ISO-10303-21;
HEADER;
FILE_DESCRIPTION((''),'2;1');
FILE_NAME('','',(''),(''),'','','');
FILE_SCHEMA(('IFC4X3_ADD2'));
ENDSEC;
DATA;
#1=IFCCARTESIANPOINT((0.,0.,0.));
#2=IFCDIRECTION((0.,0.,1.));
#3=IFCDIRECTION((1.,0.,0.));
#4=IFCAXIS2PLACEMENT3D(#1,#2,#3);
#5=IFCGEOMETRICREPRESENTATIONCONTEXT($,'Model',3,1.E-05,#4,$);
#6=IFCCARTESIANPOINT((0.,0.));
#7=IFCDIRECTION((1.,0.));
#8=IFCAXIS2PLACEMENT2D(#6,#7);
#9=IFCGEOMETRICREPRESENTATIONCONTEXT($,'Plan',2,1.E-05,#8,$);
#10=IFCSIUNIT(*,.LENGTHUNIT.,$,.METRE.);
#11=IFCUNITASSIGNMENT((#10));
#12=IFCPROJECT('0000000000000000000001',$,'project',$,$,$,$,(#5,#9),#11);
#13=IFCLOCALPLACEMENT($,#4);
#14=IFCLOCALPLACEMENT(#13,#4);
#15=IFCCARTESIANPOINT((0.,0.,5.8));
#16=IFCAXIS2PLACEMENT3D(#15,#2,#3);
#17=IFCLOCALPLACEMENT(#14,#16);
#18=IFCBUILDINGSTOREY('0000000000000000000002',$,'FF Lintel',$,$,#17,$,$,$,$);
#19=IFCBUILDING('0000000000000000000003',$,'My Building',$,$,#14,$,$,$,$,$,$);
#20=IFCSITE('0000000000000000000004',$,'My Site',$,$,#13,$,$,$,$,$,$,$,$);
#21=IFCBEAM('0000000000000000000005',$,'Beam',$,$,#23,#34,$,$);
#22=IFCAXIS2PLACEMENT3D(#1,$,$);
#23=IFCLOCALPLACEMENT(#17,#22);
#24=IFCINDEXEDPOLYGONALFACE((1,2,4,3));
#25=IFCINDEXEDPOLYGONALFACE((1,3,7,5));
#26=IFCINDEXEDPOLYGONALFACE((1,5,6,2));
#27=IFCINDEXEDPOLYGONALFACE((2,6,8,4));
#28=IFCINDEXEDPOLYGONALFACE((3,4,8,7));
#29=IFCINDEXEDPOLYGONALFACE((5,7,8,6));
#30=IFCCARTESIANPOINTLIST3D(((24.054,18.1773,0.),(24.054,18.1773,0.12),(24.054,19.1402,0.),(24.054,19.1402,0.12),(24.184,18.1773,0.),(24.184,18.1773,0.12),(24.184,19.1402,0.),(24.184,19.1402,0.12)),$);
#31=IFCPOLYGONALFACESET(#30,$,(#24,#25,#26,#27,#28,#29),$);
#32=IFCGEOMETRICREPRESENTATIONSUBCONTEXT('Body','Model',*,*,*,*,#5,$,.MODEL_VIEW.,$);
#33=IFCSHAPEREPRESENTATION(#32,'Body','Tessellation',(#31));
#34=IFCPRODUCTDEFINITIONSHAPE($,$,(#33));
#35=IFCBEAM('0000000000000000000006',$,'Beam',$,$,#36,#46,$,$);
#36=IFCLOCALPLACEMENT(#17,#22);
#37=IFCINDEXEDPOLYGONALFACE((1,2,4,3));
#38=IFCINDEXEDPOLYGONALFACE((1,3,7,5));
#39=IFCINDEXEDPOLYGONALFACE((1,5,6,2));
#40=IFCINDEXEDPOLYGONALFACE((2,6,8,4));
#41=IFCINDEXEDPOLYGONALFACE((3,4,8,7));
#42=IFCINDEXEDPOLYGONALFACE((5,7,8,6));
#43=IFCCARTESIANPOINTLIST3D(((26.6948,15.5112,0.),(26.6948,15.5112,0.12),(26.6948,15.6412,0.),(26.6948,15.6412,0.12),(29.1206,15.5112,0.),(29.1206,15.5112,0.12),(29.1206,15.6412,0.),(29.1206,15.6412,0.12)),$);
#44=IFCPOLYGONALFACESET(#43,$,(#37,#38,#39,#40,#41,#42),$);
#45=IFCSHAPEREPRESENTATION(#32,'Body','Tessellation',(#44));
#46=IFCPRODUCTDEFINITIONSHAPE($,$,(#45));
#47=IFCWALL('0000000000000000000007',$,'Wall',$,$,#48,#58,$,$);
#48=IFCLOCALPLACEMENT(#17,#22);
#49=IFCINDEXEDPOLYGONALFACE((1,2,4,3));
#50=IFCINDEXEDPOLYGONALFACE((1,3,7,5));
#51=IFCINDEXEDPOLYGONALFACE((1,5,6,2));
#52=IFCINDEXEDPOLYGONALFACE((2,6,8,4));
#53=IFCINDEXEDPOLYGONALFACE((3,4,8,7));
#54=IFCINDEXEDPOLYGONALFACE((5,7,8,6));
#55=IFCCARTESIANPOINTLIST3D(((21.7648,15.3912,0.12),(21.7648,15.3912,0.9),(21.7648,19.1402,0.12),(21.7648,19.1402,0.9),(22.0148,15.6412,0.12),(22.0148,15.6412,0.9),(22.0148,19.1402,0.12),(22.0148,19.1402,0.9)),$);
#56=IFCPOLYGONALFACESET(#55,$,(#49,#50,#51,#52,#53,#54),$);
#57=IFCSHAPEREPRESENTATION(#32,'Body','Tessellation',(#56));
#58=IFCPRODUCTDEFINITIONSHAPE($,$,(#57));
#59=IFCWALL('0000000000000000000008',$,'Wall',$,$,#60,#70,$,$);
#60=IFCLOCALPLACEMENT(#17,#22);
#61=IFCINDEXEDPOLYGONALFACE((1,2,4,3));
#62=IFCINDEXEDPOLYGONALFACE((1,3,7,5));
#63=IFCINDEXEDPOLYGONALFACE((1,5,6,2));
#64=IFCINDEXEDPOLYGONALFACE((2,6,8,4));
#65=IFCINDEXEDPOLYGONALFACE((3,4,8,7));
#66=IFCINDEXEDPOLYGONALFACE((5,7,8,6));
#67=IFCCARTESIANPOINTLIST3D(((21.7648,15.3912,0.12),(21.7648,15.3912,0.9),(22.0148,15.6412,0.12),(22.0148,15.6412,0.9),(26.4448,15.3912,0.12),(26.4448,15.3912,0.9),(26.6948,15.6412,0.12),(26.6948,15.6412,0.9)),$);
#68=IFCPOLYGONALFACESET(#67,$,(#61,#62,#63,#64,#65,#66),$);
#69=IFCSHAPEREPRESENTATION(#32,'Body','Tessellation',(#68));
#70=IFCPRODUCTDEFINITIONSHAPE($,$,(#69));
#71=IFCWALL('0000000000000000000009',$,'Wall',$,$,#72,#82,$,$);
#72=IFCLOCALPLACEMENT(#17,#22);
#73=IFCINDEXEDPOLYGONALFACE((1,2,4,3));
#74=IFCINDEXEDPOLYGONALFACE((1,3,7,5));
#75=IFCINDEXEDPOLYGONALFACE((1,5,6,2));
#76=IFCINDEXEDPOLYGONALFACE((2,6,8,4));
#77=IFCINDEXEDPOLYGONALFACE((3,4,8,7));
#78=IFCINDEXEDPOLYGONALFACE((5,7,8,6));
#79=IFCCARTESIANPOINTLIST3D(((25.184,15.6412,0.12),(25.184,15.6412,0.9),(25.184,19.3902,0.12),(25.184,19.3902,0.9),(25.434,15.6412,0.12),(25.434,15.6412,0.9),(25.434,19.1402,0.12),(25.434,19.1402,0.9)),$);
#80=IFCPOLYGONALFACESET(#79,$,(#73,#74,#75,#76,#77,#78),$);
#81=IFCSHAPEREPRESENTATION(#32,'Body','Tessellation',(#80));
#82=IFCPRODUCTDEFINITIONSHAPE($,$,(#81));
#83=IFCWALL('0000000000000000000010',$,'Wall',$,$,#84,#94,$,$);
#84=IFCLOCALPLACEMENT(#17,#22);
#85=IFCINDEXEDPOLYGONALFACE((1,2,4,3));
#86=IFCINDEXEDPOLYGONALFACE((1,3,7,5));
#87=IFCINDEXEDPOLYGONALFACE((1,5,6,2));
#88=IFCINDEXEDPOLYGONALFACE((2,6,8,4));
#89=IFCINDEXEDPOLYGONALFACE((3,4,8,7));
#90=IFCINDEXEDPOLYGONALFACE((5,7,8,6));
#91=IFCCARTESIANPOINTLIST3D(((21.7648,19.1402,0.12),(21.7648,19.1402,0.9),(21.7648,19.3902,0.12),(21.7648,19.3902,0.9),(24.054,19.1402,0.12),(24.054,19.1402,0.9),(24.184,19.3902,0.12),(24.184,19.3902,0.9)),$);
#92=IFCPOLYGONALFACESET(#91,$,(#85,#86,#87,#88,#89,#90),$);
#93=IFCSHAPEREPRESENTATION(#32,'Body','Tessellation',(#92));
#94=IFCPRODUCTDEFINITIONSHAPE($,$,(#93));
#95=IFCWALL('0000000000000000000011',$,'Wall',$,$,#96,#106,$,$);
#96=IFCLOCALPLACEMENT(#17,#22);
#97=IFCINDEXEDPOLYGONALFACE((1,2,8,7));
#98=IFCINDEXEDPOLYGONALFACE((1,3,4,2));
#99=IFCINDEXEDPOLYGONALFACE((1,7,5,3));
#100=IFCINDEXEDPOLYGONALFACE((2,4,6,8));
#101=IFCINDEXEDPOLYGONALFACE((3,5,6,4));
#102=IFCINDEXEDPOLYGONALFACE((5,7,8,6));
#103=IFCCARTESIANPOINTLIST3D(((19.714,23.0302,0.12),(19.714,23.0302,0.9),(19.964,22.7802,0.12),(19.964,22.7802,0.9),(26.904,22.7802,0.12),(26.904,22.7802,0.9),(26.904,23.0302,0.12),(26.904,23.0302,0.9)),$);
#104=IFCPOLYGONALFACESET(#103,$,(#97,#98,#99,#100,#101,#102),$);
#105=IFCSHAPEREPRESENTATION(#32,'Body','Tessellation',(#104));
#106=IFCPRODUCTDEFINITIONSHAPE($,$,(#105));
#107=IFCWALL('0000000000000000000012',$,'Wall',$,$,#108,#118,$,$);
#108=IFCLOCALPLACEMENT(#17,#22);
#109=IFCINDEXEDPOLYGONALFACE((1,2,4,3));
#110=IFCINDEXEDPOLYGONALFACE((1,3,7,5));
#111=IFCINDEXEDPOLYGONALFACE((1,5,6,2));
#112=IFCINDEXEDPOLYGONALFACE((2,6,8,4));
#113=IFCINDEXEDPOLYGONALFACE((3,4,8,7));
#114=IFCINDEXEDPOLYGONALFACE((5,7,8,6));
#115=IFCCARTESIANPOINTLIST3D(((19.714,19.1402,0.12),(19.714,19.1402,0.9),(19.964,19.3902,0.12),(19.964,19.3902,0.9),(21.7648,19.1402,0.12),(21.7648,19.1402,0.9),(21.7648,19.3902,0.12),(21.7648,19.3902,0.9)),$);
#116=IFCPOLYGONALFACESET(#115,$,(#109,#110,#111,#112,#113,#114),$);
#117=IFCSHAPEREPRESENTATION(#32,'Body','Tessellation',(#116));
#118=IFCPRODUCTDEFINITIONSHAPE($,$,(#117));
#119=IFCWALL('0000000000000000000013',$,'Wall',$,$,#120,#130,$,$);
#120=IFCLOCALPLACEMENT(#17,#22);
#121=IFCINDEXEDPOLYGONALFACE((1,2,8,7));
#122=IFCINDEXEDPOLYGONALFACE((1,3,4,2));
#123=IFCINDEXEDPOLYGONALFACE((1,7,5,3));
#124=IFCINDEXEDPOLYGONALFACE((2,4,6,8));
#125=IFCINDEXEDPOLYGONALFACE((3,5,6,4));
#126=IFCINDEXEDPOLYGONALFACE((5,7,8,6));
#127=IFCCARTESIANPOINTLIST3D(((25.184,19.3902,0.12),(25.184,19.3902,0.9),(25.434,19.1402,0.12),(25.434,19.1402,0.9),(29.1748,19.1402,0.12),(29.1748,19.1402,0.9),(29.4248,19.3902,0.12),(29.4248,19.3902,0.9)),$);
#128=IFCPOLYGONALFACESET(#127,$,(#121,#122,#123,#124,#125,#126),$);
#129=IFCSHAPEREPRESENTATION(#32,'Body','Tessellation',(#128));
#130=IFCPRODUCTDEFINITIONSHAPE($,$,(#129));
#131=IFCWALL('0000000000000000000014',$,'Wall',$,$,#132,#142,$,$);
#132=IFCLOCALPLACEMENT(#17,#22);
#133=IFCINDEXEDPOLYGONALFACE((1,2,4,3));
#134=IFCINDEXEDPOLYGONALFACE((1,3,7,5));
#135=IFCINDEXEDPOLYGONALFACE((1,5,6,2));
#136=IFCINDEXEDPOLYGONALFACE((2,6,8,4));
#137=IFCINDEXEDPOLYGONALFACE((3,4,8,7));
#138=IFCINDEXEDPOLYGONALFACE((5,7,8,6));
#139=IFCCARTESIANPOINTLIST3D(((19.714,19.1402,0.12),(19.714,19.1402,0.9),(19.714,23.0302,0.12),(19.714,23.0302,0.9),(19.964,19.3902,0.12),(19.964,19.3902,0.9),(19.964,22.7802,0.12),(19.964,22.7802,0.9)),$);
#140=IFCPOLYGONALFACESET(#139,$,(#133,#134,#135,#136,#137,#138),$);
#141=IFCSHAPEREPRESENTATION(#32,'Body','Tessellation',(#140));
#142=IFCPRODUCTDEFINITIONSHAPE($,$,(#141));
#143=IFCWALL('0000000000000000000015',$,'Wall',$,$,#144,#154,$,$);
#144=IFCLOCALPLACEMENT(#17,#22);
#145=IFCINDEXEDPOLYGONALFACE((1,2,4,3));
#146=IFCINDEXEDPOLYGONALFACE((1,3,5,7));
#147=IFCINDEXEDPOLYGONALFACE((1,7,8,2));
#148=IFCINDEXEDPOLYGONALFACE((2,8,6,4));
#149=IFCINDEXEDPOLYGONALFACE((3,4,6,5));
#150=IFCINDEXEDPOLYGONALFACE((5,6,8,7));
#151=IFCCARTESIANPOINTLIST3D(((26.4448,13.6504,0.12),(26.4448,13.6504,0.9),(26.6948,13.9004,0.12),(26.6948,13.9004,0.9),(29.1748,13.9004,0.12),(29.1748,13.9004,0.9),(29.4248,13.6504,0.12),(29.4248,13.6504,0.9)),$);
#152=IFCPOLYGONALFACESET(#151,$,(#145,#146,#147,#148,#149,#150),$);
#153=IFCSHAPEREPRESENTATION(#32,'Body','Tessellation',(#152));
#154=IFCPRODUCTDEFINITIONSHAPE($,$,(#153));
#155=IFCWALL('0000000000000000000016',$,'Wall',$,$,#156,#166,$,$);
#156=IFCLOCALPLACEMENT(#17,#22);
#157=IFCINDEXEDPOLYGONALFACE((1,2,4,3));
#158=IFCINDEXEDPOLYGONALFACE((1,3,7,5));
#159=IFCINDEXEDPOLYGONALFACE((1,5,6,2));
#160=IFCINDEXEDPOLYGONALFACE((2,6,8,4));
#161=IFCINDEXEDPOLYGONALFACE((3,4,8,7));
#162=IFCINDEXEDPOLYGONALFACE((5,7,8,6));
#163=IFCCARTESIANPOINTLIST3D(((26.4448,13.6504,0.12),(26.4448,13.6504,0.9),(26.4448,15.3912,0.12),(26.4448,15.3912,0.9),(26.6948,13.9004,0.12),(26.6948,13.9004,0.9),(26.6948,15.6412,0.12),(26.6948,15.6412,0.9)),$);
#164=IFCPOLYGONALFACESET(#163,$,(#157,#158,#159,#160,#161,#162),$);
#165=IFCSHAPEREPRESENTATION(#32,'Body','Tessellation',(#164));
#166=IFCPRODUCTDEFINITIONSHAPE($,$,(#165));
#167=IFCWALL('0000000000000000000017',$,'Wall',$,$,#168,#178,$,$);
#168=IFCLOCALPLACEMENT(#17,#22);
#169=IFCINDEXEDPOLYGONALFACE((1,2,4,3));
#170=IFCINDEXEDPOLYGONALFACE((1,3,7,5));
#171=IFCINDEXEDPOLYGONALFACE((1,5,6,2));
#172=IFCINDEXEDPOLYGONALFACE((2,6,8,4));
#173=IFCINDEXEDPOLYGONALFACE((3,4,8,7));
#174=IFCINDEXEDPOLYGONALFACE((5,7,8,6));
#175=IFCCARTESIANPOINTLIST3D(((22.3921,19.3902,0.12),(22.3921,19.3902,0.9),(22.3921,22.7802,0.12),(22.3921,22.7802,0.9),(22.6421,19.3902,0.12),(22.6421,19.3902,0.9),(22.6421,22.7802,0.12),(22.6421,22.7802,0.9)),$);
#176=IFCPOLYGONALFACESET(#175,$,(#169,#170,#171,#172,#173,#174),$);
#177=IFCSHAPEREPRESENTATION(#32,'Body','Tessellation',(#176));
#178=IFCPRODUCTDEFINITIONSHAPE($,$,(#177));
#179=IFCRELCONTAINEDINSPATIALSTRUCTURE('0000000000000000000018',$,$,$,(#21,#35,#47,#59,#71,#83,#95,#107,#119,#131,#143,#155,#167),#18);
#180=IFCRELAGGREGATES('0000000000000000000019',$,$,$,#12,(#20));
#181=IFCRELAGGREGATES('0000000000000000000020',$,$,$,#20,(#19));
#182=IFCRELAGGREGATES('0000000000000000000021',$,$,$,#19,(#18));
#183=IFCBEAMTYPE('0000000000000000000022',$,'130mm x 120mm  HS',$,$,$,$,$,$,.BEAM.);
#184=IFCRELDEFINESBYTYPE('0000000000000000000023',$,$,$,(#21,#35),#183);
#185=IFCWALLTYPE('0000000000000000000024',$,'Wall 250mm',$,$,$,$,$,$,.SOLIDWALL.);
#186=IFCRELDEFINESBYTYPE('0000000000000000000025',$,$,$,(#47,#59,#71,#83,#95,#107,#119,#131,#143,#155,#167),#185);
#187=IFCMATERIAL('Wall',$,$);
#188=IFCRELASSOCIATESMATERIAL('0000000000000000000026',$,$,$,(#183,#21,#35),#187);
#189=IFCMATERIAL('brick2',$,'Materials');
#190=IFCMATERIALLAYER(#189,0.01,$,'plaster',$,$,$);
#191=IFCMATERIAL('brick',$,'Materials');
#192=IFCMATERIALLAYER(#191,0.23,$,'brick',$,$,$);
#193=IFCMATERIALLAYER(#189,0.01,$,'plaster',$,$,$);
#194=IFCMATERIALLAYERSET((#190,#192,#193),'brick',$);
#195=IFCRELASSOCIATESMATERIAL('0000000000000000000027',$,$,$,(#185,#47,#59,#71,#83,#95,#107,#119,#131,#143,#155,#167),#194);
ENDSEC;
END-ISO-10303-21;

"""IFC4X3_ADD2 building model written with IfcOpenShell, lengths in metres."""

from ifc_helpers import new_model, si_unit, frame, origin_with_axes, origin_2d_with_axis, place, context, subcontext, project, spatial, line, indexed_curve, rectangle, outline, extrude, material, layer, layer_set, layer_usage, material_profile, profile_set, profile_usage, type_object, element, save


model = new_model("IFC4X3_ADD2")

# Units and contexts
model_context = context("Model", 3, precision=1e-05, world=origin_with_axes())
plan_context = context("Plan", 2, precision=1e-05, world=origin_2d_with_axis())
body_context = subcontext(model_context, "Body", "Model", "MODEL_VIEW")
ifc_project = project(units=[si_unit("LENGTHUNIT", "METRE")], contexts=[model_context, plan_context])

# Site, building, storey
site_placement = place(None, origin_with_axes())
site = spatial("IfcSite", under=ifc_project, at=site_placement, Name="My Site")
building_placement = place(site_placement, origin_with_axes())
building = spatial("IfcBuilding", under=site, at=building_placement, Name="My Building")
storey_placement = place(building_placement, frame((0.0, 0.0, 5.8), z_axis=(0.0, 0.0, 1.0), x_axis=(1.0, 0.0, 0.0)))
storey = spatial("IfcBuildingStorey", under=building, at=storey_placement, Name="FF Lintel")

# Beams
ifc_material_1 = material(Name="Wall")
ifc_material_profile_1 = material_profile(ifc_material_1, rectangle(XDim=0.13, YDim=0.12))
ifc_profile_set_1 = profile_set([ifc_material_profile_1], Name="concrete")
beam_type_1 = type_object("IfcBeamType", Name="130mm x 120mm  HS", PredefinedType="BEAM", material=ifc_profile_set_1)
ifc_profile_usage_1 = profile_usage(ifc_profile_set_1)
beam_1_placement = place(storey_placement, frame((24.119, 19.1402, 0.06), z_axis=(0.0, -1.0, 0.0), x_axis=(1.0, 0.0, 0.0)))
element("IfcBeam", 1, at=beam_1_placement, inside=storey, type_object=beam_type_1, material=ifc_profile_usage_1, Name="Beam", context=body_context, shape_type="SweptSolid", body=[
    extrude(rectangle(XDim=0.13, YDim=0.12), origin_with_axes(), (0.0, 0.0, 1.0), 0.9629),
])
ifc_profile_usage_2 = profile_usage(ifc_profile_set_1)
beam_2_placement = place(storey_placement, frame((29.1206, 15.5762, 0.06), z_axis=(-1.0, 0.0, 0.0), x_axis=(0.0, -1.0, 0.0)))
element("IfcBeam", 2, at=beam_2_placement, inside=storey, type_object=beam_type_1, material=ifc_profile_usage_2, Name="Beam", context=body_context, shape_type="SweptSolid", body=[
    extrude(rectangle(XDim=0.13, YDim=0.12), origin_with_axes(), (0.0, 0.0, 1.0), 2.4258),
])

# Walls
ifc_material_2 = material(Name="brick2", Category="Materials")
ifc_layer_1 = layer(ifc_material_2, 0.01, Name="plaster")
ifc_material_3 = material(Name="brick", Category="Materials")
ifc_layer_2 = layer(ifc_material_3, 0.23, Name="brick")
ifc_layer_3 = layer(ifc_material_2, 0.01, Name="plaster")
ifc_layer_set_1 = layer_set([ifc_layer_1, ifc_layer_2, ifc_layer_3], Name="brick")
ifc_layer_usage_1 = layer_usage(ifc_layer_set_1, "AXIS2", "NEGATIVE", 0.0)
wall_type_1 = type_object("IfcWallType", Name="Wall 250mm", PredefinedType="SOLIDWALL", material=ifc_layer_set_1)
wall_1_placement = place(storey_placement, frame((21.7648, 15.3912, 0.12), z_axis=(0.0, 0.0, 1.0), x_axis=(0.000001, 1.0, 0.0)))
element("IfcWall", 3, at=wall_1_placement, inside=storey, type_object=wall_type_1, material=ifc_layer_usage_1, Name="Wall", context=body_context, shape_type="SweptSolid", body=[
    extrude(outline(indexed_curve([(0.25, -0.25), (0.0, 0.0), (3.749, 0.0), (3.749, -0.25)], segments=[line(1, 2, 3, 4, 1)])), origin_with_axes(), (0.0, 0.0, 1.0), 0.78),
])
ifc_layer_usage_2 = layer_usage(ifc_layer_set_1, "AXIS2", "NEGATIVE", 0.0)
wall_2_placement = place(storey_placement, frame((26.4448, 15.3912, 0.12), z_axis=(0.0, 0.0, 1.0), x_axis=(-1.0, 0.0, 0.0)))
element("IfcWall", 4, at=wall_2_placement, inside=storey, type_object=wall_type_1, material=ifc_layer_usage_2, Name="Wall", context=body_context, shape_type="SweptSolid", body=[
    extrude(outline(indexed_curve([(-0.25, -0.25), (0.0, 0.0), (4.68, 0.0), (4.43, -0.25)], segments=[line(1, 2, 3, 4, 1)])), origin_with_axes(), (0.0, 0.0, 1.0), 0.78),
])
ifc_layer_usage_3 = layer_usage(ifc_layer_set_1, "AXIS2", "POSITIVE", 0.0)
wall_3_placement = place(storey_placement, frame((25.434, 15.3912, 0.12), z_axis=(0.0, 0.0, 1.0), x_axis=(0.000001, 1.0, 0.0)))
element("IfcWall", 5, at=wall_3_placement, inside=storey, type_object=wall_type_1, material=ifc_layer_usage_3, Name="Wall", context=body_context, shape_type="SweptSolid", body=[
    extrude(outline(indexed_curve([(0.25, 0.0), (0.25, 0.25), (3.999, 0.25), (3.749, 0.0)], segments=[line(1, 2, 3, 4, 1)])), origin_with_axes(), (0.0, 0.0, 1.0), 0.78),
])
ifc_layer_usage_4 = layer_usage(ifc_layer_set_1, "AXIS2", "POSITIVE", 0.0)
wall_4_placement = place(storey_placement, frame((24.184, 19.3902, 0.12), z_axis=(0.0, 0.0, 1.0), x_axis=(-1.0, 0.0, 0.0)))
element("IfcWall", 6, at=wall_4_placement, inside=storey, type_object=wall_type_1, material=ifc_layer_usage_4, Name="Wall", context=body_context, shape_type="SweptSolid", body=[
    extrude(outline(indexed_curve([(0.0, 0.0), (0.13, 0.25), (2.4192, 0.25), (2.4192, 0.0)], segments=[line(1, 2, 3, 4, 1)])), origin_with_axes(), (0.0, 0.0, 1.0), 0.78),
])
ifc_layer_usage_5 = layer_usage(ifc_layer_set_1, "AXIS2", "POSITIVE", 0.0)
wall_5_placement = place(storey_placement, frame((26.904, 23.0302, 0.12), z_axis=(0.0, 0.0, 1.0), x_axis=(-1.0, 0.0, 0.0)))
element("IfcWall", 7, at=wall_5_placement, inside=storey, type_object=wall_type_1, material=ifc_layer_usage_5, Name="Wall", context=body_context, shape_type="SweptSolid", body=[
    extrude(outline(indexed_curve([(0.0, 0.0), (0.0, 0.25), (6.94, 0.25), (7.19, 0.0)], segments=[line(1, 2, 3, 4, 1)])), origin_with_axes(), (0.0, 0.0, 1.0), 0.78),
])
ifc_layer_usage_6 = layer_usage(ifc_layer_set_1, "AXIS2", "NEGATIVE", 0.0)
wall_6_placement = place(storey_placement, frame((21.7648, 19.1402, 0.12), z_axis=(0.0, 0.0, 1.0), x_axis=(-1.0, 0.0, 0.0)))
element("IfcWall", 8, at=wall_6_placement, inside=storey, type_object=wall_type_1, material=ifc_layer_usage_6, Name="Wall", context=body_context, shape_type="SweptSolid", body=[
    extrude(outline(indexed_curve([(0.0, -0.25), (0.0, 0.0), (2.0508, 0.0), (1.8008, -0.25)], segments=[line(1, 2, 3, 4, 1)])), origin_with_axes(), (0.0, 0.0, 1.0), 0.78),
])
ifc_layer_usage_7 = layer_usage(ifc_layer_set_1, "AXIS2", "NEGATIVE", 0.0)
wall_7_placement = place(storey_placement, frame((29.4248, 19.1402, 0.12), z_axis=(0.0, 0.0, 1.0), x_axis=(-1.0, 0.0, 0.0)))
element("IfcWall", 9, at=wall_7_placement, inside=storey, type_object=wall_type_1, material=ifc_layer_usage_7, Name="Wall", context=body_context, shape_type="SweptSolid", body=[
    extrude(outline(indexed_curve([(0.0, -0.25), (0.25, 0.0), (3.9908, 0.0), (4.2408, -0.25)], segments=[line(1, 2, 3, 4, 1)])), origin_with_axes(), (0.0, 0.0, 1.0), 0.78),
])
ifc_layer_usage_8 = layer_usage(ifc_layer_set_1, "AXIS2", "NEGATIVE", 0.0)
wall_8_placement = place(storey_placement, frame((19.714, 19.1402, 0.12), z_axis=(0.0, 0.0, 1.0), x_axis=(0.000001, 1.0, 0.0)))
element("IfcWall", 10, at=wall_8_placement, inside=storey, type_object=wall_type_1, material=ifc_layer_usage_8, Name="Wall", context=body_context, shape_type="SweptSolid", body=[
    extrude(outline(indexed_curve([(0.25, -0.25), (0.0, 0.0), (3.89, 0.0), (3.64, -0.25)], segments=[line(1, 2, 3, 4, 1)])), origin_with_axes(), (0.0, 0.0, 1.0), 0.78),
])
ifc_layer_usage_9 = layer_usage(ifc_layer_set_1, "AXIS2", "NEGATIVE", 0.0)
wall_9_placement = place(storey_placement, frame((29.4248, 13.6504, 0.12), z_axis=(0.0, 0.0, 1.0), x_axis=(-1.0, 0.0, 0.0)))
element("IfcWall", 11, at=wall_9_placement, inside=storey, type_object=wall_type_1, material=ifc_layer_usage_9, Name="Wall", context=body_context, shape_type="SweptSolid", body=[
    extrude(outline(indexed_curve([(0.25, -0.25), (0.0, 0.0), (2.98, 0.0), (2.73, -0.25)], segments=[line(1, 2, 3, 4, 1)])), origin_with_axes(), (0.0, 0.0, 1.0), 0.78),
])
ifc_layer_usage_10 = layer_usage(ifc_layer_set_1, "AXIS2", "NEGATIVE", 0.0)
wall_10_placement = place(storey_placement, frame((26.4448, 13.6504, 0.12), z_axis=(0.0, 0.0, 1.0), x_axis=(0.000001, 1.0, 0.0)))
element("IfcWall", 12, at=wall_10_placement, inside=storey, type_object=wall_type_1, material=ifc_layer_usage_10, Name="Wall", context=body_context, shape_type="SweptSolid", body=[
    extrude(outline(indexed_curve([(0.25, -0.25), (0.0, 0.0), (1.7408, 0.0), (1.9908, -0.25)], segments=[line(1, 2, 3, 4, 1)])), origin_with_axes(), (0.0, 0.0, 1.0), 0.78),
])
ifc_layer_usage_11 = layer_usage(ifc_layer_set_1, "AXIS2", "POSITIVE", 0.0)
wall_11_placement = place(storey_placement, frame((22.6421, 19.3902, 0.12), z_axis=(0.0, 0.0, 1.0), x_axis=(0.000001, 1.0, 0.0)))
element("IfcWall", 13, at=wall_11_placement, inside=storey, type_object=wall_type_1, material=ifc_layer_usage_11, Name="Wall", context=body_context, shape_type="SweptSolid", body=[
    extrude(outline(indexed_curve([(0.0, 0.0), (0.0, 0.25), (3.39, 0.25), (3.39, 0.0)], segments=[line(1, 2, 3, 4, 1)])), origin_with_axes(), (0.0, 0.0, 1.0), 0.78),
])

save(model, "model.ifc")
